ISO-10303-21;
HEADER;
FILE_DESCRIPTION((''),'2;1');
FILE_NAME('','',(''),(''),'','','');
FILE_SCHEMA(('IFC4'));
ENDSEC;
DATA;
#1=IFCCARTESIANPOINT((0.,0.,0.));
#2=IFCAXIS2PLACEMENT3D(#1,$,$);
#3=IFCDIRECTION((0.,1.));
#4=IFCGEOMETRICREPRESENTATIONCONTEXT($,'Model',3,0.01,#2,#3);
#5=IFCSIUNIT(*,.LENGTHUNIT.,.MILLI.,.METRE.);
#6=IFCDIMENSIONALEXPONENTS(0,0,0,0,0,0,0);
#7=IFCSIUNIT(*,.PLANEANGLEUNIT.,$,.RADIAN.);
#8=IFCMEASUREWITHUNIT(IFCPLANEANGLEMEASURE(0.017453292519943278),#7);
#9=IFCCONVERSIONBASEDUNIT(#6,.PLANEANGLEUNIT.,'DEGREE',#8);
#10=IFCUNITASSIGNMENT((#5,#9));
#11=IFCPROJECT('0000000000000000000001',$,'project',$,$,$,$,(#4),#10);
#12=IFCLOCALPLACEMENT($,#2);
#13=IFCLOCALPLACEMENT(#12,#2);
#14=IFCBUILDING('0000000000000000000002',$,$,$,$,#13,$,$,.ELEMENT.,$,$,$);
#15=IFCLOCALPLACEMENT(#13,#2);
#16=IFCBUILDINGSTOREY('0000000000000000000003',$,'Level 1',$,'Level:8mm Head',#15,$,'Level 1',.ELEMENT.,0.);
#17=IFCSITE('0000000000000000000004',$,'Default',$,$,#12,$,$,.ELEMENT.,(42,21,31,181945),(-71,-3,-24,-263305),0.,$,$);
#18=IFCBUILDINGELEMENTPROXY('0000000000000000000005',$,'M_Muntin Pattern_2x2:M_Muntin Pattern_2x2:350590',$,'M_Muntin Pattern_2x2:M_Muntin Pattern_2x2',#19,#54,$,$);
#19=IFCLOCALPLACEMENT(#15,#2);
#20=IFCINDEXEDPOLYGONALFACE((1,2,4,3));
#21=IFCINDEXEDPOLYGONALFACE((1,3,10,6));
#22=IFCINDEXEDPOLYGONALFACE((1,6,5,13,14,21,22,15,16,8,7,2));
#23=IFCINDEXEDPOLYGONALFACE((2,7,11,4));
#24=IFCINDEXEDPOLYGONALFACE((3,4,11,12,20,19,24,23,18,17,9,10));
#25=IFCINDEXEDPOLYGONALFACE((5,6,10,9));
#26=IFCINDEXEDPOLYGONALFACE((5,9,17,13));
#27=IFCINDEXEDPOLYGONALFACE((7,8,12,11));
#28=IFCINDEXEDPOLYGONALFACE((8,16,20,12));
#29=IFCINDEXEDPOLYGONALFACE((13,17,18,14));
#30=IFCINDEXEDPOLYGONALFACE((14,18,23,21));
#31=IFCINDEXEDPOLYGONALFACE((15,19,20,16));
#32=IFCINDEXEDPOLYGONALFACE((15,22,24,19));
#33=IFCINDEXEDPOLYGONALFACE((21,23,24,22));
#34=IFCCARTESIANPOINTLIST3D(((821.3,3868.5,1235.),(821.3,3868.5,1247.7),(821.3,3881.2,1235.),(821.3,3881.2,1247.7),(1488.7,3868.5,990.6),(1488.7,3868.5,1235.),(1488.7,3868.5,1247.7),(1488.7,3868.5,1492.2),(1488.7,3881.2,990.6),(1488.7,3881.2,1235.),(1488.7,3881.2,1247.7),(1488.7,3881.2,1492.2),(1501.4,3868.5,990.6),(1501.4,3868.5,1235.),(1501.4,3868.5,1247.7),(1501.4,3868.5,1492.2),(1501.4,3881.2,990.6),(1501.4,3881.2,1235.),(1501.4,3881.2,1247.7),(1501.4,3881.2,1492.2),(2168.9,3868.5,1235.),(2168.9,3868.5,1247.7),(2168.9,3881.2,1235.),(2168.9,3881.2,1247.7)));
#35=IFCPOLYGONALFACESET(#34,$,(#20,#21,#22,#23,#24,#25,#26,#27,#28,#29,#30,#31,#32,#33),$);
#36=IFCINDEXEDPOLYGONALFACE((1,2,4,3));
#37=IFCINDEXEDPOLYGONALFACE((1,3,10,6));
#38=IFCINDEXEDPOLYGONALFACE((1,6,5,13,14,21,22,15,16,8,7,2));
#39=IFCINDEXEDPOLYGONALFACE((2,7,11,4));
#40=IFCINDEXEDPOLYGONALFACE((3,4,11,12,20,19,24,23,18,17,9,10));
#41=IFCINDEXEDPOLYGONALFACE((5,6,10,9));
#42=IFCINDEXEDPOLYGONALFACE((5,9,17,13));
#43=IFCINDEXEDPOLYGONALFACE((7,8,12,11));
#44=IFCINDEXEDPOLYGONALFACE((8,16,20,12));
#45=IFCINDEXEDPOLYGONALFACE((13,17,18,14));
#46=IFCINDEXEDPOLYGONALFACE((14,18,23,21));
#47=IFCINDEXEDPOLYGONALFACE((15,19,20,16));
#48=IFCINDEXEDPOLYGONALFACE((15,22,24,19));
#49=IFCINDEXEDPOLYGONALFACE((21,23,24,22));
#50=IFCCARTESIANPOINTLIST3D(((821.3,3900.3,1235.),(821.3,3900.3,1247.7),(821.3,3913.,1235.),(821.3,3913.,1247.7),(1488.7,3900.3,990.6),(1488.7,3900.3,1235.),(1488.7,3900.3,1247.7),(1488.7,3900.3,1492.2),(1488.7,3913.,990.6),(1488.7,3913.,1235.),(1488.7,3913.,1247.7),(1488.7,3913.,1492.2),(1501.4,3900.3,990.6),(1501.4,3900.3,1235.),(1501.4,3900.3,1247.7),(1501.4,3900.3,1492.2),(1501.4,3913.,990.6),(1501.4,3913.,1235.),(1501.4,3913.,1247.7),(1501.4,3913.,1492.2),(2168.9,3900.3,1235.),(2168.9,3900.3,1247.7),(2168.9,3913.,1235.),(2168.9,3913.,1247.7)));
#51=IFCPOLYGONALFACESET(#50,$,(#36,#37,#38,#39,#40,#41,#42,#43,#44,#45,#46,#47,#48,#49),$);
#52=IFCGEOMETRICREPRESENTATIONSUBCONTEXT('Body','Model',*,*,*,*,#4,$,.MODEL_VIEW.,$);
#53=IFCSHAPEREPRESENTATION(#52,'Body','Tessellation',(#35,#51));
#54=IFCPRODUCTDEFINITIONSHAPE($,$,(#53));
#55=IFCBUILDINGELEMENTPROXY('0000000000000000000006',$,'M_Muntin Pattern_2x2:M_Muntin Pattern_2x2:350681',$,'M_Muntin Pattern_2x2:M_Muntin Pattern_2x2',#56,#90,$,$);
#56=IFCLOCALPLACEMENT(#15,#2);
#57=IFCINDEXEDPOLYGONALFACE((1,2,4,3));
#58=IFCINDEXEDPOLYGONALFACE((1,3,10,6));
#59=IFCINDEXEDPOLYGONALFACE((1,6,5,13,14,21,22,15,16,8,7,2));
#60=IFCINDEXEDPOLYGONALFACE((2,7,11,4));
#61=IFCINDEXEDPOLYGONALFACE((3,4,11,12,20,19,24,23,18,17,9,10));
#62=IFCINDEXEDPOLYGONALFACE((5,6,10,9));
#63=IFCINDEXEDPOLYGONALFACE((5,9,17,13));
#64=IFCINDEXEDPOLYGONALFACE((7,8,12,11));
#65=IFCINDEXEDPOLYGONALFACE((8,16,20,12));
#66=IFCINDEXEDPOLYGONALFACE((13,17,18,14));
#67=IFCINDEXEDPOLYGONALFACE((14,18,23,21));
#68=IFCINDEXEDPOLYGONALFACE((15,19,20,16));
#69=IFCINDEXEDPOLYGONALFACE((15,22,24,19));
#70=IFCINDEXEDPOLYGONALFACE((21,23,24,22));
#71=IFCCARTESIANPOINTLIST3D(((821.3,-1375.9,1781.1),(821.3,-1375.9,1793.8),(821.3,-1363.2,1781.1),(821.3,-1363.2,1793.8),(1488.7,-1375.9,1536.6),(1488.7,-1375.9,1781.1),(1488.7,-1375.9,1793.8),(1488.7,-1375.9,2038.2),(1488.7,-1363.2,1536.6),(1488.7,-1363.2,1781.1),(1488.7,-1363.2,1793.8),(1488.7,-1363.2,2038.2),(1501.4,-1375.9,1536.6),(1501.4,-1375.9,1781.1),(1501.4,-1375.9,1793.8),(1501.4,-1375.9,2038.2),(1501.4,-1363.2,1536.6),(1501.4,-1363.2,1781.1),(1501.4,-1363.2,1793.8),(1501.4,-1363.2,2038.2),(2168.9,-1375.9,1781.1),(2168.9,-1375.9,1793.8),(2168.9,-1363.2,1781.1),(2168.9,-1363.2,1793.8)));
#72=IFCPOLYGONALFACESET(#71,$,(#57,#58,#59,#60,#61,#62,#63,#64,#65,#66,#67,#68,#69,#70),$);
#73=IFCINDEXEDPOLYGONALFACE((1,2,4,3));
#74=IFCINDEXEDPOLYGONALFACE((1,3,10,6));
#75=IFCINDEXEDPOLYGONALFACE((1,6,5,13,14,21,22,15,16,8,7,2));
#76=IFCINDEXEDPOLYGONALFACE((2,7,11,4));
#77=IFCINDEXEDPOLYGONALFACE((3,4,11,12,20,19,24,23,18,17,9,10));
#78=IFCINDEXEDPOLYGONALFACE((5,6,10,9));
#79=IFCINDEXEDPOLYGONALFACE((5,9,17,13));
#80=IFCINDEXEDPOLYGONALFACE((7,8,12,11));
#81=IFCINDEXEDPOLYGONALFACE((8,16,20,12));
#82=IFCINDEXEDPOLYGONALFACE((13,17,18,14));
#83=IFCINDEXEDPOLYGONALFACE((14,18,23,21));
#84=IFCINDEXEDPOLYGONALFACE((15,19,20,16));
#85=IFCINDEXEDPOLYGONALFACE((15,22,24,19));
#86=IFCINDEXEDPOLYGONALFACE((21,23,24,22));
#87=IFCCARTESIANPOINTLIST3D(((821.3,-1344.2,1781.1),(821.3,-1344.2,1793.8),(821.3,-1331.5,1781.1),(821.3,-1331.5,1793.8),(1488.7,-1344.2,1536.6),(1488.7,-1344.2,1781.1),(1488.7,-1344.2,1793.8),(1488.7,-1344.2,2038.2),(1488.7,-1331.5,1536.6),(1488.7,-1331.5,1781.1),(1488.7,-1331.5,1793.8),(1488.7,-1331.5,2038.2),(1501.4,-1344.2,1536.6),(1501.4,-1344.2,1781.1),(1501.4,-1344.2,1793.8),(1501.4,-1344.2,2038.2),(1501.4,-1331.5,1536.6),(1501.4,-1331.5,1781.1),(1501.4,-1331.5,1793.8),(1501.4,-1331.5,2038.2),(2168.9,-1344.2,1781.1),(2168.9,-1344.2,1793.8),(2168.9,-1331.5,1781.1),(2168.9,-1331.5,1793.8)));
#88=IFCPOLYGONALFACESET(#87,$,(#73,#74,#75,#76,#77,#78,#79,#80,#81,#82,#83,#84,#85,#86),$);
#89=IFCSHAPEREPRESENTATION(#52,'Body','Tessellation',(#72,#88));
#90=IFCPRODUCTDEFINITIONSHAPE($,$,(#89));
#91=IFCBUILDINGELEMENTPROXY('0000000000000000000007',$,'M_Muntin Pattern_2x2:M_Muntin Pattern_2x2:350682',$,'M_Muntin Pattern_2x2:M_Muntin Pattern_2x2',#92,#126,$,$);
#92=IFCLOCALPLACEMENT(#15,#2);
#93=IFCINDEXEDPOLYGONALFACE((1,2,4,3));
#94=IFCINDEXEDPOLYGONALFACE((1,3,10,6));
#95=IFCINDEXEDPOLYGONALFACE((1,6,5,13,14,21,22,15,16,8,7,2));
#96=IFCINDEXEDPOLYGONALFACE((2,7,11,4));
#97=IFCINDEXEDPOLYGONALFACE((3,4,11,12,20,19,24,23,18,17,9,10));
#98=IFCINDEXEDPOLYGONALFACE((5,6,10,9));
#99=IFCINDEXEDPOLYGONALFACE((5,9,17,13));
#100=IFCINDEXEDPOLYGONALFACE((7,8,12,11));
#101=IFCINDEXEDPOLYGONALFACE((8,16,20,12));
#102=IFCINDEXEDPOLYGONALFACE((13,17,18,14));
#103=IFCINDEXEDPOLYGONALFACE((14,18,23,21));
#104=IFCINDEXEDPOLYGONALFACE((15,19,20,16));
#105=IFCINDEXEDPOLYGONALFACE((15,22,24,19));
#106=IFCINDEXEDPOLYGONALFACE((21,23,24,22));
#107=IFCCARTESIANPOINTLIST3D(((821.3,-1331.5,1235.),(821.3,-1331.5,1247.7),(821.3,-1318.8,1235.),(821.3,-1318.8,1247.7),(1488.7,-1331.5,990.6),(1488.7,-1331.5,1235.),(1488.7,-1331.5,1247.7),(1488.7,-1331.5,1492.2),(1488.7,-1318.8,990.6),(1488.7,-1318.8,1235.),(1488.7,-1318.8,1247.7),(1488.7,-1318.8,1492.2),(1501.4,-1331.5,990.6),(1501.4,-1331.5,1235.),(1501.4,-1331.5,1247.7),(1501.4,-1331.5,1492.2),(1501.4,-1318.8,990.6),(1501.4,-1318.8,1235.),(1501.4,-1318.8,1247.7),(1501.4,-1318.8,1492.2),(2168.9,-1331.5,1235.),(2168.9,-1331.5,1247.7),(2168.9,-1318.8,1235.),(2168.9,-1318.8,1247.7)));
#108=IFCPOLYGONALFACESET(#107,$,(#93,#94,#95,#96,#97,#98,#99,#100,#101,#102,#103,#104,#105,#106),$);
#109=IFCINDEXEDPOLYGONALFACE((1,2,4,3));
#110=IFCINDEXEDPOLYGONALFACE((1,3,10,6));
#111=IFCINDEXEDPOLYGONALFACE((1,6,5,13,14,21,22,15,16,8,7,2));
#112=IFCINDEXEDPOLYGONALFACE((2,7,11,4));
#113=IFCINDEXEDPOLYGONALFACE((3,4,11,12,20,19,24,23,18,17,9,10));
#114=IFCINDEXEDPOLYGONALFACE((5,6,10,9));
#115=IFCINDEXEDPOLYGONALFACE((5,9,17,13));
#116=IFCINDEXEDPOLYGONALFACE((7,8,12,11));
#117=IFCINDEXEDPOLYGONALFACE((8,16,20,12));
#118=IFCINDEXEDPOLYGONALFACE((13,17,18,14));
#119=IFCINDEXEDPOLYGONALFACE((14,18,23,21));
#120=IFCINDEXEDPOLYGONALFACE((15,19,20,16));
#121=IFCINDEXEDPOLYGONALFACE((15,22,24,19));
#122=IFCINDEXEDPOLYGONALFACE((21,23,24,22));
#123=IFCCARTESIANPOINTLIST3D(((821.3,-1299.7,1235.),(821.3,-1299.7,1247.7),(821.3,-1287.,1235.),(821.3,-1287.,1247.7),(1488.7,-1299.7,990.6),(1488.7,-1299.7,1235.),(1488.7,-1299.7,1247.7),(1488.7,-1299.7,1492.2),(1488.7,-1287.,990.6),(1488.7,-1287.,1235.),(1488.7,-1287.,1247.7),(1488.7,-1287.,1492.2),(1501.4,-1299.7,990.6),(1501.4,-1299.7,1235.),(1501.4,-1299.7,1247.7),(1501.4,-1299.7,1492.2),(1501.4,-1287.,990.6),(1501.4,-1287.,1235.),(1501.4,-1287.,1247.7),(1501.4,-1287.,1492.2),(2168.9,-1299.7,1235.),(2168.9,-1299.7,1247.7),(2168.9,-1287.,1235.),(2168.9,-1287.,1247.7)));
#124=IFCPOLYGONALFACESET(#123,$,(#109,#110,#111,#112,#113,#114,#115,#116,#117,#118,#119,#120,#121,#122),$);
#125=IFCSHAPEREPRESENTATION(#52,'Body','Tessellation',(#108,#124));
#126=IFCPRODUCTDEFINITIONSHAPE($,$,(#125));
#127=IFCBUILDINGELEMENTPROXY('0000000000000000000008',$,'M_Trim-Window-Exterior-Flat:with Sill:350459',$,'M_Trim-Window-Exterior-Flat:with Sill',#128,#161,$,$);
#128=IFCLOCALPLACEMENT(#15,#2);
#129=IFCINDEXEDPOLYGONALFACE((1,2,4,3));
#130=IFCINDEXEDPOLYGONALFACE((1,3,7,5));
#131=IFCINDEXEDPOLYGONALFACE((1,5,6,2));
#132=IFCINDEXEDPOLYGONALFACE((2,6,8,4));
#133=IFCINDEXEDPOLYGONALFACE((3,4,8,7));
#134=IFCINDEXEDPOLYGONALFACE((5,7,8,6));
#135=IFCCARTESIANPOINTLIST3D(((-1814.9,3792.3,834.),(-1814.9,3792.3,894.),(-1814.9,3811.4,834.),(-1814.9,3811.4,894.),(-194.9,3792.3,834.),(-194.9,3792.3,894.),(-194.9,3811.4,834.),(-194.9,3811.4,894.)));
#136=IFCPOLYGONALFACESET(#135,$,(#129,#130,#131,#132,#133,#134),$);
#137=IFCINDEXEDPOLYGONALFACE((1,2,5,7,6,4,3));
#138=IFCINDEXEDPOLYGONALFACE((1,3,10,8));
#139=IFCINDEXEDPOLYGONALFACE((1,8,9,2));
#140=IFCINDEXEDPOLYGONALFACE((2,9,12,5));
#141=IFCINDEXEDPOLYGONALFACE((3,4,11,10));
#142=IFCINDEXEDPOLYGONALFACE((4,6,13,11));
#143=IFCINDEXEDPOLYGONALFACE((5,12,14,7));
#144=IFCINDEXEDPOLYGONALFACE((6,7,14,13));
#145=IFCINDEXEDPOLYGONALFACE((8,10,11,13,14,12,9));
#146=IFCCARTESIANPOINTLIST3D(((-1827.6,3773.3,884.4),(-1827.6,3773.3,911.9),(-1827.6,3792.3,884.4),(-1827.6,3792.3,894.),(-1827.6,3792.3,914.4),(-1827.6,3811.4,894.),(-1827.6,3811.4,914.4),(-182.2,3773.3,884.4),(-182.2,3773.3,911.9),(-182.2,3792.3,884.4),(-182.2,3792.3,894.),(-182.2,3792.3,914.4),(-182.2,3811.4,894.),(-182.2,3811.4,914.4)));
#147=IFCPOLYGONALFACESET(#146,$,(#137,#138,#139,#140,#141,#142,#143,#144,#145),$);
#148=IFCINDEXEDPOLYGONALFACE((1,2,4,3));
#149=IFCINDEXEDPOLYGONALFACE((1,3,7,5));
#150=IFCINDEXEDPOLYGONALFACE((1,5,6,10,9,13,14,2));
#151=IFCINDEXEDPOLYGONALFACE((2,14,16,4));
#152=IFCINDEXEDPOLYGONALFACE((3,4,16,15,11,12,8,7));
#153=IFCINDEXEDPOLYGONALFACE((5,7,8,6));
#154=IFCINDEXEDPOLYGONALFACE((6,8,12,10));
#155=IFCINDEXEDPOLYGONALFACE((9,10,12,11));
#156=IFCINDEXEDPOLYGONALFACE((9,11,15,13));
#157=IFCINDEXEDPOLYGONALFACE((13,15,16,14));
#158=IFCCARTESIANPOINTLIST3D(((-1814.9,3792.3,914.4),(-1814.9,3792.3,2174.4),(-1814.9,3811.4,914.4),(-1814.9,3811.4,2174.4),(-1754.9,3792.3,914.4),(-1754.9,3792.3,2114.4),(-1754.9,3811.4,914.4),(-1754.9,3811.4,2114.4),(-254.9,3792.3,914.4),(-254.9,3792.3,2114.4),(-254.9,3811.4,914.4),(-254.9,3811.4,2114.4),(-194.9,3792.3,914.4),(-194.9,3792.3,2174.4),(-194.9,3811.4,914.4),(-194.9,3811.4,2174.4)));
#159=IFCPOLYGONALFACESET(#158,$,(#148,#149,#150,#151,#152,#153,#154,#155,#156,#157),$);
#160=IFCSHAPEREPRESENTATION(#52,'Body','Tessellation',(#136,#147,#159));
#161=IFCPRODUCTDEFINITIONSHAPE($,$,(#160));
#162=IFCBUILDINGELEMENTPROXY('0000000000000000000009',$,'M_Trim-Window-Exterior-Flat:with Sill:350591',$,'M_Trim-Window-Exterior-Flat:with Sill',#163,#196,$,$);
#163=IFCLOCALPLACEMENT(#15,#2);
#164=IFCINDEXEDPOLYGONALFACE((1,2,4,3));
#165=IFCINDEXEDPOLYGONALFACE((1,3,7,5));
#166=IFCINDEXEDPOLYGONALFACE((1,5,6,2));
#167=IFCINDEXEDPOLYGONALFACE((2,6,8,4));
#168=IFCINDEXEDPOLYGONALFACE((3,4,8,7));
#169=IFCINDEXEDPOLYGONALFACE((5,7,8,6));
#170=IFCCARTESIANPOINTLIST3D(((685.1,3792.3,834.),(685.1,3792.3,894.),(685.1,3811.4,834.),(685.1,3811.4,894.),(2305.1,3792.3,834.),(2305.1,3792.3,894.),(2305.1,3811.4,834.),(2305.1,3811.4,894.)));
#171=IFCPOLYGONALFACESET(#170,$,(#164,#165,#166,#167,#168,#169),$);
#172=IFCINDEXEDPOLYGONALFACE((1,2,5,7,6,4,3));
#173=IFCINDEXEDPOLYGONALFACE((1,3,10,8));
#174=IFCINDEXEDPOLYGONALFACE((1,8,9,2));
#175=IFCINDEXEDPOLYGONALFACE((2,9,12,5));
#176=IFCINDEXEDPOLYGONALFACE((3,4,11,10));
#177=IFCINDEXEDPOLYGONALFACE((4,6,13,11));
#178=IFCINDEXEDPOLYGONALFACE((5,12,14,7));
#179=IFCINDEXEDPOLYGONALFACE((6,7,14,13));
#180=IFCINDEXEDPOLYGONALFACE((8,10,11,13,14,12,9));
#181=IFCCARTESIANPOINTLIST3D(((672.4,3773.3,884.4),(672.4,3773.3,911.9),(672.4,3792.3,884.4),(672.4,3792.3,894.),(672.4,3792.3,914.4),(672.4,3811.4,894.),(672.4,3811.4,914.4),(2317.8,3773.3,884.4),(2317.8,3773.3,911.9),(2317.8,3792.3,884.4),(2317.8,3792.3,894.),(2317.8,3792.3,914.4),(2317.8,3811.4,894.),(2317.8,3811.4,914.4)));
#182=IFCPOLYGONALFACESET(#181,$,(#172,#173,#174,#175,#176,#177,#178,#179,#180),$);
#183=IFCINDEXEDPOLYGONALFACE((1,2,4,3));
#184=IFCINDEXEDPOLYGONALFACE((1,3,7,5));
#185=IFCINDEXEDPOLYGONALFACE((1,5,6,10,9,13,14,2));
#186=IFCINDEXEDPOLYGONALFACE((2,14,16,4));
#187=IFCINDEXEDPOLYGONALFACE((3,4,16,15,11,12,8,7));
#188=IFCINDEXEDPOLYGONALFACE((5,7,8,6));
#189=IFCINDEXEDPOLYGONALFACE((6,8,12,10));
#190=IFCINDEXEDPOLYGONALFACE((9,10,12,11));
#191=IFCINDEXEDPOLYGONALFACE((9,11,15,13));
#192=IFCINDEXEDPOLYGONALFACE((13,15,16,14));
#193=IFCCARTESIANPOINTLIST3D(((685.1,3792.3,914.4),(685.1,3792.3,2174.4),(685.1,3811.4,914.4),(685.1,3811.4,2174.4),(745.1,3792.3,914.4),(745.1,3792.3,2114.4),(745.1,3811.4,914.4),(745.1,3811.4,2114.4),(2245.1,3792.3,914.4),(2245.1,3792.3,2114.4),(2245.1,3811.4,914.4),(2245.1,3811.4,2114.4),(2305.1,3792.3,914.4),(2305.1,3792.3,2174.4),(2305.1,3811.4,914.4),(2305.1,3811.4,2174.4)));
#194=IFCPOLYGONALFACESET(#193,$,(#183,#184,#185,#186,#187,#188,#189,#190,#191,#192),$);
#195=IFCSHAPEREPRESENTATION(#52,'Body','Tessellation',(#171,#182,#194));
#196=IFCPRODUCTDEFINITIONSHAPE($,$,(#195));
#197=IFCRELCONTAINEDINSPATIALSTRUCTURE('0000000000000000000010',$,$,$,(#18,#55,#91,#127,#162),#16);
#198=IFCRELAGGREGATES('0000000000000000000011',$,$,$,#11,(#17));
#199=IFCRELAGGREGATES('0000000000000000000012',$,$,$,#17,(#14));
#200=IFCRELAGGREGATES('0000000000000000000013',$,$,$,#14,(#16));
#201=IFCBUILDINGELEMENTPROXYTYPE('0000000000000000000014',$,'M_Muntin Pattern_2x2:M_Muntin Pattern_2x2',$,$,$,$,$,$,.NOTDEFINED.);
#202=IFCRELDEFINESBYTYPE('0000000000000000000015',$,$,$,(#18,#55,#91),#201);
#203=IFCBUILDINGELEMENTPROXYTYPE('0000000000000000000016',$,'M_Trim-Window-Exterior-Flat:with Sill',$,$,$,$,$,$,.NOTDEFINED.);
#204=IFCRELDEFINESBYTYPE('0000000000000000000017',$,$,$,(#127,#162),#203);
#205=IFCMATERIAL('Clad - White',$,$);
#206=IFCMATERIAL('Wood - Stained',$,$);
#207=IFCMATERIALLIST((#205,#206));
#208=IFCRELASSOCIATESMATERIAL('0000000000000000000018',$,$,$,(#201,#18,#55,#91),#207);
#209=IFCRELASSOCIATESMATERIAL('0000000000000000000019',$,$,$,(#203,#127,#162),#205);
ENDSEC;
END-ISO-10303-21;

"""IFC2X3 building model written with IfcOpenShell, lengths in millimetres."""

from ifc_helpers import new_model, entity, si_unit, converted_unit, direction, frame, frame_2d, origin, place, context, subcontext, project, spatial, polyline, rectangle, outline, extrude, source, transform, mapped, material, material_list, type_object, type_shapes, element, save


model = new_model("IFC2X3")

# Units and contexts
model_context = context("Model", 3, precision=0.01, world=origin(), true_north=direction((0.0, 1.0)))
body_context = subcontext(model_context, "Body", "Model", "MODEL_VIEW")
ifc_project = project(units=[si_unit("LENGTHUNIT", "METRE", prefix="MILLI"), converted_unit("PLANEANGLEUNIT", "DEGREE", entity("IfcPlaneAngleMeasure", 0.017453292519943278), si_unit("PLANEANGLEUNIT", "RADIAN"), dimensions=[0, 0, 0, 0, 0, 0, 0])], contexts=[model_context])

# Site, building, storey
site_placement = place(None, origin())
site = spatial("IfcSite", under=ifc_project, at=site_placement, Name="Default", CompositionType="ELEMENT", RefLatitude=(42, 21, 31, 181945), RefLongitude=(-71, -3, -24, -263305), RefElevation=0.0)
building_placement = place(site_placement, origin())
building = spatial("IfcBuilding", under=site, at=building_placement, CompositionType="ELEMENT")
storey_placement = place(building_placement, origin())
storey = spatial("IfcBuildingStorey", under=building, at=storey_placement, Name="Level 1", ObjectType="Level:8mm Head", LongName="Level 1", CompositionType="ELEMENT", Elevation=0.0)

# Shared definitions
ifc_material_1 = material(Name="Wood - Stained")

# Building element proxies
ifc_material_2 = material(Name="Clad - White")
ifc_material_list_1 = material_list([ifc_material_2, ifc_material_1])
building_element_proxy_type_1 = type_object("IfcBuildingElementProxyType", Name="M_Muntin Pattern_2x2:M_Muntin Pattern_2x2", PredefinedType="NOTDEFINED", material=ifc_material_list_1)
shared_shape_1 = source(origin(), body_context, "Body", "SweptSolid", [
    extrude(outline(polyline([(6.4, -6.4), (250.8, -6.4), (250.8, 6.3), (6.4, 6.3), (6.4, 673.8), (-6.3, 673.8), (-6.3, 6.3), (-250.8, 6.3), (-250.8, -6.4), (-6.3, -6.4), (-6.3, -673.8), (6.4, -673.8), (6.4, -6.4)])), frame((0.0, 9.5, 250.8), z_axis=(0.0, 1.0, 0.0), x_axis=(0.0, 0.0, 1.0)), (0.0, 0.0, 1.0), 12.7),
    extrude(outline(polyline([(6.4, -6.4), (250.8, -6.4), (250.8, 6.3), (6.4, 6.3), (6.4, 673.8), (-6.3, 673.8), (-6.3, 6.3), (-250.8, 6.3), (-250.8, -6.4), (-6.3, -6.4), (-6.3, -673.8), (6.4, -673.8), (6.4, -6.4)])), frame((0.0, -22.2, 250.8), z_axis=(0.0, 1.0, 0.0), x_axis=(0.0, 0.0, 1.0)), (0.0, 0.0, 1.0), 12.7),
])
type_shapes(building_element_proxy_type_1, [shared_shape_1])
for number, where, z_axis, x_axis, name in (
    (1, (1495.1, 3890.7, 990.6), (0.0, 0.0, 1.0), (-1.0, 0.0, 0.0), "M_Muntin Pattern_2x2:M_Muntin Pattern_2x2:350590"),
    (2, (1495.1, -1353.7, 1536.6), (0.0, 0.0, 1.0), (-1.0, 0.0, 0.0), "M_Muntin Pattern_2x2:M_Muntin Pattern_2x2:350681"),
    (3, (1495.1, -1309.3, 990.6), (0.0, 0.0, 1.0), (-1.0, 0.0, 0.0), "M_Muntin Pattern_2x2:M_Muntin Pattern_2x2:350682"),
):
    element("IfcBuildingElementProxy", number, at=place(storey_placement, frame(where, z_axis=z_axis, x_axis=x_axis)), inside=storey, type_object=building_element_proxy_type_1, material=ifc_material_list_1, Name=name, ObjectType="M_Muntin Pattern_2x2:M_Muntin Pattern_2x2", context=body_context, shape_type="MappedRepresentation", body=[
        mapped(shared_shape_1, transform((0.0, 0.0, 0.0), scale=1.0)),
    ])
building_element_proxy_type_2 = type_object("IfcBuildingElementProxyType", Name="M_Trim-Window-Exterior-Flat:with Sill", PredefinedType="NOTDEFINED", material=ifc_material_2)
shared_shape_2 = source(origin(), body_context, "Body", "SweptSolid", [
    extrude(rectangle(XDim=1620.0, YDim=60.0, at=frame_2d((0.0, 0.0), x_axis=(1.0, 0.0))), frame((0.0, -1250.4, 0.0), z_axis=(0.0, 0.0, 1.0), x_axis=(-1.0, 0.0, 0.0)), (0.0, 0.0, 1.0), 19.0),
    extrude(outline(polyline([(-19.0, -15.2), (0.0, -15.2), (0.0, -5.7), (19.0, -5.7), (19.0, 14.8), (0.0, 14.8), (-19.0, 12.3), (-19.0, -15.2)])), frame((-822.7, -1214.8, 19.0), z_axis=(1.0, 0.0, 0.0), x_axis=(0.0, 0.0, -1.0)), (0.0, 0.0, 1.0), 1645.4),
    extrude(outline(polyline([(-645.0, -810.0), (615.0, -810.0), (615.0, -750.0), (-585.0, -750.0), (-585.0, 750.0), (615.0, 750.0), (615.0, 810.0), (-645.0, 810.0), (-645.0, -810.0)])), frame((0.0, -585.0, 0.0), z_axis=(0.0, 0.0, 1.0), x_axis=(0.0, -1.0, 0.0)), (0.0, 0.0, 1.0), 19.0),
])
type_shapes(building_element_proxy_type_2, [shared_shape_2])
for number, where, z_axis, x_axis, name in (
    (4, (-1004.9, 3811.4, 2114.4), (0.0, -1.0, 0.0), (1.0, 0.0, 0.0), "M_Trim-Window-Exterior-Flat:with Sill:350459"),
    (5, (1495.1, 3811.4, 2114.4), (0.0, -1.0, 0.0), (1.0, 0.0, 0.0), "M_Trim-Window-Exterior-Flat:with Sill:350591"),
):
    element("IfcBuildingElementProxy", number, at=place(storey_placement, frame(where, z_axis=z_axis, x_axis=x_axis)), inside=storey, type_object=building_element_proxy_type_2, material=ifc_material_2, Name=name, ObjectType="M_Trim-Window-Exterior-Flat:with Sill", context=body_context, shape_type="MappedRepresentation", body=[
        mapped(shared_shape_2, transform((0.0, 0.0, 0.0), scale=1.0)),
    ])

save(model, "model.ifc")
